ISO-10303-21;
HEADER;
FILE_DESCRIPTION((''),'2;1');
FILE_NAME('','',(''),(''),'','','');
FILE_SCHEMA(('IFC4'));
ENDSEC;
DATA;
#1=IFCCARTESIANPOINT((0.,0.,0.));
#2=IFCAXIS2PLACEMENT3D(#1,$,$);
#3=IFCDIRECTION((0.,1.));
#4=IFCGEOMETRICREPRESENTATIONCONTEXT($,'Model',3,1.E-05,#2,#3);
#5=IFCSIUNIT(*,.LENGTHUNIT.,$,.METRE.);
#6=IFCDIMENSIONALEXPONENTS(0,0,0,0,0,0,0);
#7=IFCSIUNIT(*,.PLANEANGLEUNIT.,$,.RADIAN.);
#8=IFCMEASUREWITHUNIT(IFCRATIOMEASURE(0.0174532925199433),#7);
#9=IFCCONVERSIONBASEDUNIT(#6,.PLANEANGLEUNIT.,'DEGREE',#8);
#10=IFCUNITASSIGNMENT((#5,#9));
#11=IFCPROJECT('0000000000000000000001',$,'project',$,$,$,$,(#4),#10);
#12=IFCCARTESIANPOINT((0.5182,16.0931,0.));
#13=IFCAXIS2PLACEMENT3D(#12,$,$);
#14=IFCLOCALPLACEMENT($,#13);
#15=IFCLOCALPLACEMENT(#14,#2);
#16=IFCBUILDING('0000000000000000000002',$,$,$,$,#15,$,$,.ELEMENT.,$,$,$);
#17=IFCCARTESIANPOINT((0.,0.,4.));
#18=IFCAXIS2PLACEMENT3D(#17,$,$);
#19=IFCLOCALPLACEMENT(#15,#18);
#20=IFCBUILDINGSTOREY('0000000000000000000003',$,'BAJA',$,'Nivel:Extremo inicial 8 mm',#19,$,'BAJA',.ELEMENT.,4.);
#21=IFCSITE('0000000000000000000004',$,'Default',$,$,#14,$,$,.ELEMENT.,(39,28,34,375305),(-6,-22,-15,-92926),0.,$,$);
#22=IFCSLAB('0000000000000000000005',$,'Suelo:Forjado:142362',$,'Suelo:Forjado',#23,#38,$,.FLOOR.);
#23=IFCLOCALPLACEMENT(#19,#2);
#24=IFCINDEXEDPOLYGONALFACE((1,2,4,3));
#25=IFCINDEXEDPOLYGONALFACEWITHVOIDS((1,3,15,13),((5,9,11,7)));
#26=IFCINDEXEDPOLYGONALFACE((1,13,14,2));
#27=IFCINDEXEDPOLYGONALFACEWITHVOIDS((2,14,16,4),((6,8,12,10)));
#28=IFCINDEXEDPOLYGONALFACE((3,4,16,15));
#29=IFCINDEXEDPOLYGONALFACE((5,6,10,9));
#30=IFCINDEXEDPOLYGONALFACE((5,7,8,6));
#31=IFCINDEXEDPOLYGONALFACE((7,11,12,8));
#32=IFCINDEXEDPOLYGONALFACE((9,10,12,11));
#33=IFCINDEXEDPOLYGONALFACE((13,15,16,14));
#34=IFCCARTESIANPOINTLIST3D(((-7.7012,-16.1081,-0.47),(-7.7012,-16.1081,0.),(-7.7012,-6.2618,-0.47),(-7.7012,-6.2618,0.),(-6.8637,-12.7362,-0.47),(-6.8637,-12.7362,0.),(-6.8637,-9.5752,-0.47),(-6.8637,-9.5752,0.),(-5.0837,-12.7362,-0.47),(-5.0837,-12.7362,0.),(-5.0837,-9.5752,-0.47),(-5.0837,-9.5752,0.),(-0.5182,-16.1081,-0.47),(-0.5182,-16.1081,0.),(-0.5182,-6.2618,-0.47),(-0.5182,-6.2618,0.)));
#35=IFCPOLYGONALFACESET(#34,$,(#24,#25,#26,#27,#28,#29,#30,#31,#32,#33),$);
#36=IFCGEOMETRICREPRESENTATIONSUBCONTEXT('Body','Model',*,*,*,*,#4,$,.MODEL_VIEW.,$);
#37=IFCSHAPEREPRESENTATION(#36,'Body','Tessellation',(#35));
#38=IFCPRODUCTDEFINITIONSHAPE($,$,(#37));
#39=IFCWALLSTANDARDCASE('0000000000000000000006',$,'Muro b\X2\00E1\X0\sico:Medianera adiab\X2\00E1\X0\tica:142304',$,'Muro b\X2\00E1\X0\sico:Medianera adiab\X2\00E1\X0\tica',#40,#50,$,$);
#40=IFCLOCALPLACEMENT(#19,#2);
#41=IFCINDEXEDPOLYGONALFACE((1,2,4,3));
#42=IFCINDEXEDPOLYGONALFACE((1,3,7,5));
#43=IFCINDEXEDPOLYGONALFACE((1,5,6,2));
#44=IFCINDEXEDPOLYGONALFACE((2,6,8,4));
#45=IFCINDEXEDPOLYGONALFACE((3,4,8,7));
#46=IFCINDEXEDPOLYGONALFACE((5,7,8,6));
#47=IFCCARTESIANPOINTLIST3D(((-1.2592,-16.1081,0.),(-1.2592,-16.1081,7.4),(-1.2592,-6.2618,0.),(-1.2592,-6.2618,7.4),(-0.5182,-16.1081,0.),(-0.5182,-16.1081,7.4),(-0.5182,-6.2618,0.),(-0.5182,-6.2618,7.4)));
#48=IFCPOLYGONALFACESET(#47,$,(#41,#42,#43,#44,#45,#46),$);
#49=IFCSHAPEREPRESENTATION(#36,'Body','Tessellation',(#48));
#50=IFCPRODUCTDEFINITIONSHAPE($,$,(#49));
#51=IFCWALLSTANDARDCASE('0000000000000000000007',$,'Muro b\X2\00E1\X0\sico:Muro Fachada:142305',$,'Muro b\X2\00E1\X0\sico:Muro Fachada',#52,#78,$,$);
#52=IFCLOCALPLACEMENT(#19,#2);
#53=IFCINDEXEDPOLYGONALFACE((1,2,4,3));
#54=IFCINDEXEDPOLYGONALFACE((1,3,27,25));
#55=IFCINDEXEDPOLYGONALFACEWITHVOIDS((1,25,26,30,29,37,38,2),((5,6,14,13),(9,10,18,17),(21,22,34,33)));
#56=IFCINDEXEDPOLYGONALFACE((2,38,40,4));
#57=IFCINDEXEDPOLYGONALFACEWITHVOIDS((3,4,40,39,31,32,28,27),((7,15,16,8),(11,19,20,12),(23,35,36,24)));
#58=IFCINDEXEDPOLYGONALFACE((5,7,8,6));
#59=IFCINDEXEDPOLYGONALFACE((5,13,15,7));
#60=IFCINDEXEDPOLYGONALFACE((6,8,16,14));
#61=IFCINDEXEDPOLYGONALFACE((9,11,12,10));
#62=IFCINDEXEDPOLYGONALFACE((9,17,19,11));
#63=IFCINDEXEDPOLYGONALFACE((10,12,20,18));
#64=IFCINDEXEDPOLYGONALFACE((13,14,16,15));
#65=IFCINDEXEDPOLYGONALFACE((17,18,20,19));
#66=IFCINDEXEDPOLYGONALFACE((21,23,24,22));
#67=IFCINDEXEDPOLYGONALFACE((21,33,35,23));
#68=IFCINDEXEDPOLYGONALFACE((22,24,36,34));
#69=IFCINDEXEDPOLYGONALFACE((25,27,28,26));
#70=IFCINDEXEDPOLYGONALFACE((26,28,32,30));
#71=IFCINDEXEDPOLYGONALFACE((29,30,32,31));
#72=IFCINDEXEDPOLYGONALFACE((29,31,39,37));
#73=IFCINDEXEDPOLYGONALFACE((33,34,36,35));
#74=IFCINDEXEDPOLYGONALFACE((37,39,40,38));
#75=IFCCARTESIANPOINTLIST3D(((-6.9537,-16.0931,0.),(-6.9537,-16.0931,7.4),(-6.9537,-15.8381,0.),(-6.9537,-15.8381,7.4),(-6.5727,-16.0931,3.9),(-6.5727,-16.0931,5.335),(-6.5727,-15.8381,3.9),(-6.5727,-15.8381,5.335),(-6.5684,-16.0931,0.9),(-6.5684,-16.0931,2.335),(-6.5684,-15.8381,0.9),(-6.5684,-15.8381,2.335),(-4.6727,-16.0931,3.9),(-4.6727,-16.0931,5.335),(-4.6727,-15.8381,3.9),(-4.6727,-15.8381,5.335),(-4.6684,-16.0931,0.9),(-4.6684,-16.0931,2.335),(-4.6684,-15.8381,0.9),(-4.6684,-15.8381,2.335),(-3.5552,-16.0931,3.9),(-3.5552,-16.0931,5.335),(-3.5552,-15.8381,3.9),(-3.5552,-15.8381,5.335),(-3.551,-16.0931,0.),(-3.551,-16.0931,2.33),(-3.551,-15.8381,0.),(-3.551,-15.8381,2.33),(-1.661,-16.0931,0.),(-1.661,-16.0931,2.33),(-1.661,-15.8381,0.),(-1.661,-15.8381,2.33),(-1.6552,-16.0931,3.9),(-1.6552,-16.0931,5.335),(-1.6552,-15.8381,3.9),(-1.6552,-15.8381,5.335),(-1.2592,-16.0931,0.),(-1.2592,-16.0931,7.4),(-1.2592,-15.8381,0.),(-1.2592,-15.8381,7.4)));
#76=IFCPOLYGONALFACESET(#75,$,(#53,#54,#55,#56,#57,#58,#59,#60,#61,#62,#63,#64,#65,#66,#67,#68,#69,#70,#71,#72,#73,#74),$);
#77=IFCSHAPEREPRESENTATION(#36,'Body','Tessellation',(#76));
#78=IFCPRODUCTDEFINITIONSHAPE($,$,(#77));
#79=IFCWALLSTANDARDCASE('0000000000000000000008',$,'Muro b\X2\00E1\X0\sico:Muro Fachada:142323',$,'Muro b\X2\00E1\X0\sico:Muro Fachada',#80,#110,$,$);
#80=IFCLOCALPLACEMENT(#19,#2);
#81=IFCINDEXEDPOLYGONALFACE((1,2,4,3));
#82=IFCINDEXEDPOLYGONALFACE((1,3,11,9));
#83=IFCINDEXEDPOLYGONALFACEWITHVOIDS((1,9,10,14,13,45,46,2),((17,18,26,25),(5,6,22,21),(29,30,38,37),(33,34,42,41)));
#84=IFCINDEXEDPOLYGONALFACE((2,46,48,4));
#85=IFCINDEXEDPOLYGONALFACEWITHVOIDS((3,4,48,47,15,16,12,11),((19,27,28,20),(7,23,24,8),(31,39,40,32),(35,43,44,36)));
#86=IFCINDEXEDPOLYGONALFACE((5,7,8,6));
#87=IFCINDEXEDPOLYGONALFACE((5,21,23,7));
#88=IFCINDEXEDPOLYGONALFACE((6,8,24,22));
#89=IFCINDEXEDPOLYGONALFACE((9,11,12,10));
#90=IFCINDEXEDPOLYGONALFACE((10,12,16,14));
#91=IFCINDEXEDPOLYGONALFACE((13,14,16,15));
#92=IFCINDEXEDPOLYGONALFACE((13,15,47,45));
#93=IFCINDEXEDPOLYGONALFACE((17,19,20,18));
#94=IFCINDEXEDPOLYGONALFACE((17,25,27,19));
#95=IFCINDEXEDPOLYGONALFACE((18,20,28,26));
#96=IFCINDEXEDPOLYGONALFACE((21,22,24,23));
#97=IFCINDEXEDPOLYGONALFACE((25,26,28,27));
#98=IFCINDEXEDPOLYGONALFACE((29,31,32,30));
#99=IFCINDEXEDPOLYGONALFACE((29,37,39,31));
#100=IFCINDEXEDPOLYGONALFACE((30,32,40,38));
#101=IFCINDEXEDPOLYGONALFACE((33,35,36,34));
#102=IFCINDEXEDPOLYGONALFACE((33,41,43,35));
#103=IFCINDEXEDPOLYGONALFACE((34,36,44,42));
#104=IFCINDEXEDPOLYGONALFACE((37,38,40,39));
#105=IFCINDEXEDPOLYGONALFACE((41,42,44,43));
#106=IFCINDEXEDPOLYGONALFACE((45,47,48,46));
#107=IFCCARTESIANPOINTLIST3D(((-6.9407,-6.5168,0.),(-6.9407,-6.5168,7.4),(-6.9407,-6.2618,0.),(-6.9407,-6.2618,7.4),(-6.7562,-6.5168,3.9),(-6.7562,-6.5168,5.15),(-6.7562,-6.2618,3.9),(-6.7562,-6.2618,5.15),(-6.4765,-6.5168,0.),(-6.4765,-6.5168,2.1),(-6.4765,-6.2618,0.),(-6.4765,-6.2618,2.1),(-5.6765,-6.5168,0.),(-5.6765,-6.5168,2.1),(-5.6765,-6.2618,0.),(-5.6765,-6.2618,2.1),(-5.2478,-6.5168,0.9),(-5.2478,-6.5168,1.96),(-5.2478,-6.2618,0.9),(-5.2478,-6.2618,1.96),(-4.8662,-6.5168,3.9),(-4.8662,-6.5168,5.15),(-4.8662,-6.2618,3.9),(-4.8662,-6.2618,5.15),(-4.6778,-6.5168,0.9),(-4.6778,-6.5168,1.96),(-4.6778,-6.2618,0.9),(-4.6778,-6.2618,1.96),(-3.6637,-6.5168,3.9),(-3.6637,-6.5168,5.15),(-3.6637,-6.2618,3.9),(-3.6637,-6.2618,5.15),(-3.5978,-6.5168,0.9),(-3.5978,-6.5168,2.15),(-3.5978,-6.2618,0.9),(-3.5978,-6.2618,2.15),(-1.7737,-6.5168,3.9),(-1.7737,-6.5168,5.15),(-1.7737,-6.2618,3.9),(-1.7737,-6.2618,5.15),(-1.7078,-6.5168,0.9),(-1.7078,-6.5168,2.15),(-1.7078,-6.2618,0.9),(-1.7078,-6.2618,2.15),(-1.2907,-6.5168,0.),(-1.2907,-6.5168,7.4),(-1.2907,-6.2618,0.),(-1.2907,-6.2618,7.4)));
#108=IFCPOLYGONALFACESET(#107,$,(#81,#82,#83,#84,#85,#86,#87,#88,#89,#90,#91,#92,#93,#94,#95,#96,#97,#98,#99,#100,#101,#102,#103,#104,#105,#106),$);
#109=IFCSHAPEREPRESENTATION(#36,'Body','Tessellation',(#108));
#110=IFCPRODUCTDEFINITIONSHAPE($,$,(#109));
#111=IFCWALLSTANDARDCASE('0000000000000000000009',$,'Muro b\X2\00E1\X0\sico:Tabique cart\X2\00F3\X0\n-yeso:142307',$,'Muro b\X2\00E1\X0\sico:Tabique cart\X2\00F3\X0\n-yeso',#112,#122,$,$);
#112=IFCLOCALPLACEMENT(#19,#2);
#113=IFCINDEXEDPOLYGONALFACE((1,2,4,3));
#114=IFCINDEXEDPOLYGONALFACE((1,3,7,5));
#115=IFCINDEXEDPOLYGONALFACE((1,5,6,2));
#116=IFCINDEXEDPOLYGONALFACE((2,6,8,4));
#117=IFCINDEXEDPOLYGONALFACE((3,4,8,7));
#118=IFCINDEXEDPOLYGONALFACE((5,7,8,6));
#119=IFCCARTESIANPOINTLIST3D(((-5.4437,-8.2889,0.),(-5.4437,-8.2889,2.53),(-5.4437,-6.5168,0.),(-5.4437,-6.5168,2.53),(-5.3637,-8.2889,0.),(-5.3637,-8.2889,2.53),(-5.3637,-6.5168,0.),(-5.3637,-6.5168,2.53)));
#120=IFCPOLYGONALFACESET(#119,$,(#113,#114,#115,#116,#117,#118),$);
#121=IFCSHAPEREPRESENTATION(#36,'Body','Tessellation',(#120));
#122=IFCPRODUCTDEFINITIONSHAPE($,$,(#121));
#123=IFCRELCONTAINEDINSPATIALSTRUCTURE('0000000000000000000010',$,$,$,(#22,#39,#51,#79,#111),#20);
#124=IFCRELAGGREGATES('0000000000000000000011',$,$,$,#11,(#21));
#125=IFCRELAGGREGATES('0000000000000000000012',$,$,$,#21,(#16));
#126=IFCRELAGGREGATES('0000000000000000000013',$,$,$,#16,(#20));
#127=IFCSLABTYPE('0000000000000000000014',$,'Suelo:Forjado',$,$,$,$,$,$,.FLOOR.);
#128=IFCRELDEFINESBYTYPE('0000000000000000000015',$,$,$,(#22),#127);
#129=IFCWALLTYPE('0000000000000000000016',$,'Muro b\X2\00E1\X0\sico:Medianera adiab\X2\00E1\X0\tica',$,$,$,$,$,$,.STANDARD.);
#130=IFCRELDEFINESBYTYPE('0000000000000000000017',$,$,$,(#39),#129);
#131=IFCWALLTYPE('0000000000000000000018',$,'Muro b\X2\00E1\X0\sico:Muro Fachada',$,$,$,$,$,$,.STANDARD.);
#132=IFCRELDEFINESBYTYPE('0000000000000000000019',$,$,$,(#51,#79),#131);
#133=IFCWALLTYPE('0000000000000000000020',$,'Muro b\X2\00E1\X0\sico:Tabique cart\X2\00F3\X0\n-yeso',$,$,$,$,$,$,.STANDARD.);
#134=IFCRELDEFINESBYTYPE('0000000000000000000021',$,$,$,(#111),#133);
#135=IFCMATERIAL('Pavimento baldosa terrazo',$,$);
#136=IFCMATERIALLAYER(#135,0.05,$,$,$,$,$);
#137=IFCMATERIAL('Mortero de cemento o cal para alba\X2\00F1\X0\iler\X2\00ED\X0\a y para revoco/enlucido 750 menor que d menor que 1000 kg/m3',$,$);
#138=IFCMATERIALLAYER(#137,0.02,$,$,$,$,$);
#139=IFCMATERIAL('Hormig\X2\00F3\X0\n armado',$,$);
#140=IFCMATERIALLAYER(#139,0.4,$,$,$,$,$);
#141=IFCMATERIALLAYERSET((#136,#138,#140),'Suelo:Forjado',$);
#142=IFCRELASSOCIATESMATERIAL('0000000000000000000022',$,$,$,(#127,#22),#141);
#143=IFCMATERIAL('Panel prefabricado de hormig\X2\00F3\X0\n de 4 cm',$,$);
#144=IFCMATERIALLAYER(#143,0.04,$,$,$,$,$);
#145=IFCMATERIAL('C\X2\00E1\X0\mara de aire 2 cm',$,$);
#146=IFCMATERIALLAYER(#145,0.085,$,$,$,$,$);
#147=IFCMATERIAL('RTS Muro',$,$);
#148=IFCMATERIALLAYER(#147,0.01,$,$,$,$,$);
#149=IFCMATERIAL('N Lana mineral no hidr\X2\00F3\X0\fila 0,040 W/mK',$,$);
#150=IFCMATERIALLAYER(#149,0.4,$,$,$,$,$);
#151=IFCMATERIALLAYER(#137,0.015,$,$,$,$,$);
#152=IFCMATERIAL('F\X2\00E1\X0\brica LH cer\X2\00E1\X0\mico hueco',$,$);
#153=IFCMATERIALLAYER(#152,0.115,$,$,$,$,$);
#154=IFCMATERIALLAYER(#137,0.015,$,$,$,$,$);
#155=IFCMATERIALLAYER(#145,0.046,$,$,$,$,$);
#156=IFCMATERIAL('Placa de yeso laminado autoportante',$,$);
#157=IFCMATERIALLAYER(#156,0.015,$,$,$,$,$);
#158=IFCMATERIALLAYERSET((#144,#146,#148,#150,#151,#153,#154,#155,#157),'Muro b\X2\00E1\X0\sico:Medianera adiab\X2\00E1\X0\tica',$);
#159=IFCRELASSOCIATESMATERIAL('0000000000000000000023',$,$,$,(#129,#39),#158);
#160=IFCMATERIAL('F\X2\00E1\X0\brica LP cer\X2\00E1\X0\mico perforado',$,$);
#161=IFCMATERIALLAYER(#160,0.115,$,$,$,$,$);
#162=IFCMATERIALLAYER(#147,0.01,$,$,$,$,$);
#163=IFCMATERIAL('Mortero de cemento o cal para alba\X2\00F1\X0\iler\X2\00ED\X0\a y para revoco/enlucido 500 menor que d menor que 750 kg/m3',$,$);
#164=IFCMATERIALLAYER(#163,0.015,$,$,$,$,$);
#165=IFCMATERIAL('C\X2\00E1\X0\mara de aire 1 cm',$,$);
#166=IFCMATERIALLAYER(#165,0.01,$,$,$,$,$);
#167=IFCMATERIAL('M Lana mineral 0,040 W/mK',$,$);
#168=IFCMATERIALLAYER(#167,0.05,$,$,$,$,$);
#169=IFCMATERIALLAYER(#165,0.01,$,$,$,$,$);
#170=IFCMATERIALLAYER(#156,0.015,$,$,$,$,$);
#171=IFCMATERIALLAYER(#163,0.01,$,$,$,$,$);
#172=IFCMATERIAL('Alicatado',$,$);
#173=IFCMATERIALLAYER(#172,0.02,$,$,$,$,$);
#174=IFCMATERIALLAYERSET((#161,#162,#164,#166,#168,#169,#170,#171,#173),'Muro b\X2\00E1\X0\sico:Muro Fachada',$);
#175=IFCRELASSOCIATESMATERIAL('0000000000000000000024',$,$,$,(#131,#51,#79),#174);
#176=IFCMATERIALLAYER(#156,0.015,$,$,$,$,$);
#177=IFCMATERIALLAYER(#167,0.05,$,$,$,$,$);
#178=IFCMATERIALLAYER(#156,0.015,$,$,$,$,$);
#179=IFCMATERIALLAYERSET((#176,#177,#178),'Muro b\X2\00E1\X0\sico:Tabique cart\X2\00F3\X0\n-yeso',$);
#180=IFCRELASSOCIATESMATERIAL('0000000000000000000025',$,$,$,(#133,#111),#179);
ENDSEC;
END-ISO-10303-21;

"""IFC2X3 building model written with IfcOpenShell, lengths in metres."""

from ifc_helpers import new_model, entity, si_unit, converted_unit, direction, frame, frame_2d, origin, place, context, subcontext, project, spatial, polyline, rectangle, extrude, clip, bounded_halfspace, material, layer, layer_set, layer_usage, type_object, element, save


model = new_model("IFC2X3")

# Units and contexts
model_context = context("Model", 3, precision=1e-05, world=origin(), true_north=direction((0.0, 1.0)))
body_context = subcontext(model_context, "Body", "Model", "MODEL_VIEW")
ifc_project = project(units=[si_unit("LENGTHUNIT", "METRE"), converted_unit("PLANEANGLEUNIT", "DEGREE", entity("IfcRatioMeasure", 0.0174532925199433), si_unit("PLANEANGLEUNIT", "RADIAN"), dimensions=[0, 0, 0, 0, 0, 0, 0])], contexts=[model_context])

# Site, building, storey
site_placement = place(None, frame((0.5182, 16.0931, 0.0)))
site = spatial("IfcSite", under=ifc_project, at=site_placement, Name="Default", CompositionType="ELEMENT", RefLatitude=(39, 28, 34, 375305), RefLongitude=(-6, -22, -15, -92926), RefElevation=0.0)
building_placement = place(site_placement, origin())
building = spatial("IfcBuilding", under=site, at=building_placement, CompositionType="ELEMENT")
storey_placement = place(building_placement, frame((0.0, 0.0, 4.0)))
storey = spatial("IfcBuildingStorey", under=building, at=storey_placement, Name="BAJA", ObjectType="Nivel:Extremo inicial 8 mm", LongName="BAJA", CompositionType="ELEMENT", Elevation=4.0)

# Slab, opening
ifc_material_1 = material(Name="Pavimento baldosa terrazo")
ifc_layer_1 = layer(ifc_material_1, 0.05)
ifc_material_2 = material(Name="Mortero de cemento o cal para albañilería y para revoco/enlucido 750 menor que d menor que 1000 kg/m3")
ifc_layer_2 = layer(ifc_material_2, 0.02)
ifc_material_3 = material(Name="Hormigón armado")
ifc_layer_3 = layer(ifc_material_3, 0.4)
ifc_layer_set_1 = layer_set([ifc_layer_1, ifc_layer_2, ifc_layer_3], Name="Suelo:Forjado")
ifc_layer_usage_1 = layer_usage(ifc_layer_set_1, "AXIS3", "POSITIVE", 0.0)
slab_type = type_object("IfcSlabType", Name="Suelo:Forjado", PredefinedType="FLOOR", material=ifc_layer_set_1)
slab_placement = place(storey_placement, frame((-7.7012, -16.1081, -0.47)))
slab = element("IfcSlab", 1, at=slab_placement, inside=storey, type_object=slab_type, material=ifc_layer_usage_1, Name="Suelo:Forjado:142362", ObjectType="Suelo:Forjado", PredefinedType="FLOOR", context=body_context, shape_type="SweptSolid", body=[
    extrude(rectangle(XDim=9.8464, YDim=7.1831, at=frame_2d((0.0, 0.0), x_axis=(0.0, 1.0))), frame((3.5915, 4.9232, 0.47), z_axis=(0.0, 0.0, -1.0), x_axis=(-1.0, 0.0, 0.0)), (0.0, 0.0, 1.0), 0.47),
])
opening_1_placement = place(slab_placement, frame((1.9056, 4.8279, 0.47)))
element("IfcOpeningElement", 2, at=opening_1_placement, cuts=slab, ObjectType="Opening", context=body_context, shape_type="SweptSolid", body=[
    extrude(rectangle(XDim=3.161, YDim=1.78, at=frame_2d((-0.1245, 0.178), x_axis=(1.0, 0.0))), frame((0.0, 0.0, 0.0), z_axis=(0.0, 0.0, -1.0), x_axis=(0.0, -1.0, 0.0)), (0.0, 0.0, 1.0), 0.47),
])

# Wall
ifc_material_4 = material(Name="Panel prefabricado de hormigón de 4 cm")
ifc_layer_4 = layer(ifc_material_4, 0.04)
ifc_material_5 = material(Name="Cámara de aire 2 cm")
ifc_layer_5 = layer(ifc_material_5, 0.085)
ifc_material_6 = material(Name="RTS Muro")
ifc_layer_6 = layer(ifc_material_6, 0.01)
ifc_material_7 = material(Name="N Lana mineral no hidrófila 0,040 W/mK")
ifc_layer_7 = layer(ifc_material_7, 0.4)
ifc_layer_8 = layer(ifc_material_2, 0.015)
ifc_material_8 = material(Name="Fábrica LH cerámico hueco")
ifc_layer_9 = layer(ifc_material_8, 0.115)
ifc_layer_10 = layer(ifc_material_2, 0.015)
ifc_layer_11 = layer(ifc_material_5, 0.046)
ifc_material_9 = material(Name="Placa de yeso laminado autoportante")
ifc_layer_12 = layer(ifc_material_9, 0.015)
ifc_layer_set_2 = layer_set([ifc_layer_4, ifc_layer_5, ifc_layer_6, ifc_layer_7, ifc_layer_8, ifc_layer_9, ifc_layer_10, ifc_layer_11, ifc_layer_12], Name="Muro básico:Medianera adiabática")
wall_type_1 = type_object("IfcWallType", Name="Muro básico:Medianera adiabática", PredefinedType="STANDARD", material=ifc_layer_set_2)
ifc_layer_usage_2 = layer_usage(ifc_layer_set_2, "AXIS2", "POSITIVE", -0.3705)
wall_1_placement = place(storey_placement, frame((-0.8887, -16.1081, 0.0), z_axis=(0.0, 0.0, 1.0), x_axis=(0.0, 1.0, 0.0)))
element("IfcWallStandardCase", 3, at=wall_1_placement, inside=storey, type_object=wall_type_1, material=ifc_layer_usage_2, Name="Muro básico:Medianera adiabática:142304", ObjectType="Muro básico:Medianera adiabática", context=body_context, shape_type="SweptSolid", body=[
    extrude(rectangle(XDim=9.8464, YDim=0.741, at=frame_2d((4.9232, 0.0), x_axis=(-1.0, 0.0))), origin(), (0.0, 0.0, 1.0), 7.4),
])

# Walls, openings
ifc_material_10 = material(Name="Fábrica LP cerámico perforado")
ifc_layer_13 = layer(ifc_material_10, 0.115)
ifc_layer_14 = layer(ifc_material_6, 0.01)
ifc_material_11 = material(Name="Mortero de cemento o cal para albañilería y para revoco/enlucido 500 menor que d menor que 750 kg/m3")
ifc_layer_15 = layer(ifc_material_11, 0.015)
ifc_material_12 = material(Name="Cámara de aire 1 cm")
ifc_layer_16 = layer(ifc_material_12, 0.01)
ifc_material_13 = material(Name="M Lana mineral 0,040 W/mK")
ifc_layer_17 = layer(ifc_material_13, 0.05)
ifc_layer_18 = layer(ifc_material_12, 0.01)
ifc_layer_19 = layer(ifc_material_9, 0.015)
ifc_layer_20 = layer(ifc_material_11, 0.01)
ifc_material_14 = material(Name="Alicatado")
ifc_layer_21 = layer(ifc_material_14, 0.02)
ifc_layer_set_3 = layer_set([ifc_layer_13, ifc_layer_14, ifc_layer_15, ifc_layer_16, ifc_layer_17, ifc_layer_18, ifc_layer_19, ifc_layer_20, ifc_layer_21], Name="Muro básico:Muro Fachada")
ifc_layer_usage_3 = layer_usage(ifc_layer_set_3, "AXIS2", "POSITIVE", -0.1275)
wall_type_2 = type_object("IfcWallType", Name="Muro básico:Muro Fachada", PredefinedType="STANDARD", material=ifc_layer_set_3)
wall_2_placement = place(storey_placement, frame((-6.9537, -15.9656, 0.0)))
wall_2 = element("IfcWallStandardCase", 4, at=wall_2_placement, inside=storey, type_object=wall_type_2, material=ifc_layer_usage_3, Name="Muro básico:Muro Fachada:142305", ObjectType="Muro básico:Muro Fachada", context=body_context, shape_type="SweptSolid", body=[
    extrude(rectangle(XDim=5.6945, YDim=0.255, at=frame_2d((2.8472, 0.0), x_axis=(-1.0, 0.0))), origin(), (0.0, 0.0, 1.0), 7.4),
])
opening_2_placement = place(wall_2_placement, frame((3.4027, -0.1275, 0.0)))
element("IfcOpeningElement", 5, at=opening_2_placement, cuts=wall_2, ObjectType="Opening", context=body_context, shape_type="SweptSolid", body=[
    extrude(rectangle(XDim=2.33, YDim=1.89, at=frame_2d((1.165, 0.945), x_axis=(1.0, 0.0))), frame((0.0, 0.0, 0.0), z_axis=(0.0, 1.0, 0.0), x_axis=(0.0, 0.0, 1.0)), (0.0, 0.0, 1.0), 0.255),
])
opening_3_placement = place(wall_2_placement, frame((0.3809, -0.1275, 3.9)))
element("IfcOpeningElement", 6, at=opening_3_placement, cuts=wall_2, ObjectType="Opening", context=body_context, shape_type="SweptSolid", body=[
    extrude(rectangle(XDim=1.435, YDim=1.9, at=frame_2d((0.7175, 0.95), x_axis=(1.0, 0.0))), frame((0.0, 0.0, 0.0), z_axis=(0.0, 1.0, 0.0), x_axis=(0.0, 0.0, 1.0)), (0.0, 0.0, 1.0), 0.255),
])
opening_4_placement = place(wall_2_placement, frame((3.3984, -0.1275, 3.9)))
element("IfcOpeningElement", 7, at=opening_4_placement, cuts=wall_2, ObjectType="Opening", context=body_context, shape_type="SweptSolid", body=[
    extrude(rectangle(XDim=1.435, YDim=1.9, at=frame_2d((0.7175, 0.95), x_axis=(1.0, 0.0))), frame((0.0, 0.0, 0.0), z_axis=(0.0, 1.0, 0.0), x_axis=(0.0, 0.0, 1.0)), (0.0, 0.0, 1.0), 0.255),
])
opening_5_placement = place(wall_2_placement, frame((0.3852, -0.1275, 0.9)))
element("IfcOpeningElement", 8, at=opening_5_placement, cuts=wall_2, ObjectType="Opening", context=body_context, shape_type="SweptSolid", body=[
    extrude(rectangle(XDim=1.435, YDim=1.9, at=frame_2d((0.7175, 0.95), x_axis=(1.0, 0.0))), frame((0.0, 0.0, 0.0), z_axis=(0.0, 1.0, 0.0), x_axis=(0.0, 0.0, 1.0)), (0.0, 0.0, 1.0), 0.255),
])
ifc_layer_usage_4 = layer_usage(ifc_layer_set_3, "AXIS2", "NEGATIVE", 0.1275)
wall_3_placement = place(storey_placement, frame((-6.9407, -6.3893, 0.0)))
wall_3 = element("IfcWallStandardCase", 9, at=wall_3_placement, inside=storey, type_object=wall_type_2, material=ifc_layer_usage_4, Name="Muro básico:Muro Fachada:142323", ObjectType="Muro básico:Muro Fachada", context=body_context, shape_type="SweptSolid", body=[
    extrude(rectangle(XDim=5.65, YDim=0.255, at=frame_2d((2.825, 0.0), x_axis=(-1.0, 0.0))), origin(), (0.0, 0.0, 1.0), 7.4),
])
opening_6_placement = place(wall_3_placement, frame((1.2642, 0.1275, 0.0)))
element("IfcOpeningElement", 10, at=opening_6_placement, cuts=wall_3, ObjectType="Opening", context=body_context, shape_type="SweptSolid", body=[
    extrude(rectangle(XDim=2.1, YDim=0.8, at=frame_2d((1.05, 0.4), x_axis=(1.0, 0.0))), frame((0.0, 0.0, 0.0), z_axis=(0.0, -1.0, 0.0), x_axis=(0.0, 0.0, 1.0)), (0.0, 0.0, 1.0), 0.255),
])
opening_7_placement = place(wall_3_placement, frame((5.2329, 0.1275, 0.9)))
element("IfcOpeningElement", 11, at=opening_7_placement, cuts=wall_3, ObjectType="Opening", context=body_context, shape_type="SweptSolid", body=[
    extrude(rectangle(XDim=1.25, YDim=1.89, at=frame_2d((0.625, 0.945), x_axis=(1.0, 0.0))), frame((0.0, 0.0, 0.0), z_axis=(0.0, -1.0, 0.0), x_axis=(0.0, 0.0, 1.0)), (0.0, 0.0, 1.0), 0.255),
])
opening_8_placement = place(wall_3_placement, frame((2.2629, 0.1275, 0.9)))
element("IfcOpeningElement", 12, at=opening_8_placement, cuts=wall_3, ObjectType="Opening", context=body_context, shape_type="SweptSolid", body=[
    extrude(rectangle(XDim=1.06, YDim=0.57, at=frame_2d((0.53, 0.285), x_axis=(1.0, 0.0))), frame((0.0, 0.0, 0.0), z_axis=(0.0, -1.0, 0.0), x_axis=(0.0, 0.0, 1.0)), (0.0, 0.0, 1.0), 0.255),
])
opening_9_placement = place(wall_3_placement, frame((5.1671, 0.1275, 3.9)))
element("IfcOpeningElement", 13, at=opening_9_placement, cuts=wall_3, ObjectType="Opening", context=body_context, shape_type="SweptSolid", body=[
    extrude(rectangle(XDim=1.25, YDim=1.89, at=frame_2d((0.625, 0.945), x_axis=(1.0, 0.0))), frame((0.0, 0.0, 0.0), z_axis=(0.0, -1.0, 0.0), x_axis=(0.0, 0.0, 1.0)), (0.0, 0.0, 1.0), 0.255),
])
opening_10_placement = place(wall_3_placement, frame((2.0746, 0.1275, 3.9)))
element("IfcOpeningElement", 14, at=opening_10_placement, cuts=wall_3, ObjectType="Opening", context=body_context, shape_type="SweptSolid", body=[
    extrude(rectangle(XDim=1.25, YDim=1.89, at=frame_2d((0.625, 0.945), x_axis=(1.0, 0.0))), frame((0.0, 0.0, 0.0), z_axis=(0.0, -1.0, 0.0), x_axis=(0.0, 0.0, 1.0)), (0.0, 0.0, 1.0), 0.255),
])

# Wall
ifc_layer_22 = layer(ifc_material_9, 0.015)
ifc_layer_23 = layer(ifc_material_13, 0.05)
ifc_layer_24 = layer(ifc_material_9, 0.015)
ifc_layer_set_4 = layer_set([ifc_layer_22, ifc_layer_23, ifc_layer_24], Name="Muro básico:Tabique cartón-yeso")
ifc_layer_usage_5 = layer_usage(ifc_layer_set_4, "AXIS2", "POSITIVE", -0.04)
wall_type_3 = type_object("IfcWallType", Name="Muro básico:Tabique cartón-yeso", PredefinedType="STANDARD", material=ifc_layer_set_4)
wall_4_placement = place(storey_placement, frame((-5.4037, -6.5168, 0.0), z_axis=(0.0, 0.0, 1.0), x_axis=(0.0, -1.0, 0.0)))
element("IfcWallStandardCase", 15, at=wall_4_placement, inside=storey, type_object=wall_type_3, material=ifc_layer_usage_5, Name="Muro básico:Tabique cartón-yeso:142307", ObjectType="Muro básico:Tabique cartón-yeso", context=body_context, shape_type="Clipping", body=[
    clip(extrude(rectangle(XDim=1.7721, YDim=0.08, at=frame_2d((0.886, 0.0), x_axis=(-1.0, 0.0))), origin(), (0.0, 0.0, 1.0), 2.53), bounded_halfspace(frame((0.0, -0.04, 2.53), z_axis=(0.0, 0.0, -1.0), x_axis=(1.0, 0.0, 0.0)), True, frame((0.0, -0.04, 2.53)), polyline([(0.0, 0.0), (1.7721, 0.0), (1.7721, 0.08), (1.6921, 0.08), (0.0, 0.08), (0.0, 0.0)]))),
])

save(model, "model.ifc")
